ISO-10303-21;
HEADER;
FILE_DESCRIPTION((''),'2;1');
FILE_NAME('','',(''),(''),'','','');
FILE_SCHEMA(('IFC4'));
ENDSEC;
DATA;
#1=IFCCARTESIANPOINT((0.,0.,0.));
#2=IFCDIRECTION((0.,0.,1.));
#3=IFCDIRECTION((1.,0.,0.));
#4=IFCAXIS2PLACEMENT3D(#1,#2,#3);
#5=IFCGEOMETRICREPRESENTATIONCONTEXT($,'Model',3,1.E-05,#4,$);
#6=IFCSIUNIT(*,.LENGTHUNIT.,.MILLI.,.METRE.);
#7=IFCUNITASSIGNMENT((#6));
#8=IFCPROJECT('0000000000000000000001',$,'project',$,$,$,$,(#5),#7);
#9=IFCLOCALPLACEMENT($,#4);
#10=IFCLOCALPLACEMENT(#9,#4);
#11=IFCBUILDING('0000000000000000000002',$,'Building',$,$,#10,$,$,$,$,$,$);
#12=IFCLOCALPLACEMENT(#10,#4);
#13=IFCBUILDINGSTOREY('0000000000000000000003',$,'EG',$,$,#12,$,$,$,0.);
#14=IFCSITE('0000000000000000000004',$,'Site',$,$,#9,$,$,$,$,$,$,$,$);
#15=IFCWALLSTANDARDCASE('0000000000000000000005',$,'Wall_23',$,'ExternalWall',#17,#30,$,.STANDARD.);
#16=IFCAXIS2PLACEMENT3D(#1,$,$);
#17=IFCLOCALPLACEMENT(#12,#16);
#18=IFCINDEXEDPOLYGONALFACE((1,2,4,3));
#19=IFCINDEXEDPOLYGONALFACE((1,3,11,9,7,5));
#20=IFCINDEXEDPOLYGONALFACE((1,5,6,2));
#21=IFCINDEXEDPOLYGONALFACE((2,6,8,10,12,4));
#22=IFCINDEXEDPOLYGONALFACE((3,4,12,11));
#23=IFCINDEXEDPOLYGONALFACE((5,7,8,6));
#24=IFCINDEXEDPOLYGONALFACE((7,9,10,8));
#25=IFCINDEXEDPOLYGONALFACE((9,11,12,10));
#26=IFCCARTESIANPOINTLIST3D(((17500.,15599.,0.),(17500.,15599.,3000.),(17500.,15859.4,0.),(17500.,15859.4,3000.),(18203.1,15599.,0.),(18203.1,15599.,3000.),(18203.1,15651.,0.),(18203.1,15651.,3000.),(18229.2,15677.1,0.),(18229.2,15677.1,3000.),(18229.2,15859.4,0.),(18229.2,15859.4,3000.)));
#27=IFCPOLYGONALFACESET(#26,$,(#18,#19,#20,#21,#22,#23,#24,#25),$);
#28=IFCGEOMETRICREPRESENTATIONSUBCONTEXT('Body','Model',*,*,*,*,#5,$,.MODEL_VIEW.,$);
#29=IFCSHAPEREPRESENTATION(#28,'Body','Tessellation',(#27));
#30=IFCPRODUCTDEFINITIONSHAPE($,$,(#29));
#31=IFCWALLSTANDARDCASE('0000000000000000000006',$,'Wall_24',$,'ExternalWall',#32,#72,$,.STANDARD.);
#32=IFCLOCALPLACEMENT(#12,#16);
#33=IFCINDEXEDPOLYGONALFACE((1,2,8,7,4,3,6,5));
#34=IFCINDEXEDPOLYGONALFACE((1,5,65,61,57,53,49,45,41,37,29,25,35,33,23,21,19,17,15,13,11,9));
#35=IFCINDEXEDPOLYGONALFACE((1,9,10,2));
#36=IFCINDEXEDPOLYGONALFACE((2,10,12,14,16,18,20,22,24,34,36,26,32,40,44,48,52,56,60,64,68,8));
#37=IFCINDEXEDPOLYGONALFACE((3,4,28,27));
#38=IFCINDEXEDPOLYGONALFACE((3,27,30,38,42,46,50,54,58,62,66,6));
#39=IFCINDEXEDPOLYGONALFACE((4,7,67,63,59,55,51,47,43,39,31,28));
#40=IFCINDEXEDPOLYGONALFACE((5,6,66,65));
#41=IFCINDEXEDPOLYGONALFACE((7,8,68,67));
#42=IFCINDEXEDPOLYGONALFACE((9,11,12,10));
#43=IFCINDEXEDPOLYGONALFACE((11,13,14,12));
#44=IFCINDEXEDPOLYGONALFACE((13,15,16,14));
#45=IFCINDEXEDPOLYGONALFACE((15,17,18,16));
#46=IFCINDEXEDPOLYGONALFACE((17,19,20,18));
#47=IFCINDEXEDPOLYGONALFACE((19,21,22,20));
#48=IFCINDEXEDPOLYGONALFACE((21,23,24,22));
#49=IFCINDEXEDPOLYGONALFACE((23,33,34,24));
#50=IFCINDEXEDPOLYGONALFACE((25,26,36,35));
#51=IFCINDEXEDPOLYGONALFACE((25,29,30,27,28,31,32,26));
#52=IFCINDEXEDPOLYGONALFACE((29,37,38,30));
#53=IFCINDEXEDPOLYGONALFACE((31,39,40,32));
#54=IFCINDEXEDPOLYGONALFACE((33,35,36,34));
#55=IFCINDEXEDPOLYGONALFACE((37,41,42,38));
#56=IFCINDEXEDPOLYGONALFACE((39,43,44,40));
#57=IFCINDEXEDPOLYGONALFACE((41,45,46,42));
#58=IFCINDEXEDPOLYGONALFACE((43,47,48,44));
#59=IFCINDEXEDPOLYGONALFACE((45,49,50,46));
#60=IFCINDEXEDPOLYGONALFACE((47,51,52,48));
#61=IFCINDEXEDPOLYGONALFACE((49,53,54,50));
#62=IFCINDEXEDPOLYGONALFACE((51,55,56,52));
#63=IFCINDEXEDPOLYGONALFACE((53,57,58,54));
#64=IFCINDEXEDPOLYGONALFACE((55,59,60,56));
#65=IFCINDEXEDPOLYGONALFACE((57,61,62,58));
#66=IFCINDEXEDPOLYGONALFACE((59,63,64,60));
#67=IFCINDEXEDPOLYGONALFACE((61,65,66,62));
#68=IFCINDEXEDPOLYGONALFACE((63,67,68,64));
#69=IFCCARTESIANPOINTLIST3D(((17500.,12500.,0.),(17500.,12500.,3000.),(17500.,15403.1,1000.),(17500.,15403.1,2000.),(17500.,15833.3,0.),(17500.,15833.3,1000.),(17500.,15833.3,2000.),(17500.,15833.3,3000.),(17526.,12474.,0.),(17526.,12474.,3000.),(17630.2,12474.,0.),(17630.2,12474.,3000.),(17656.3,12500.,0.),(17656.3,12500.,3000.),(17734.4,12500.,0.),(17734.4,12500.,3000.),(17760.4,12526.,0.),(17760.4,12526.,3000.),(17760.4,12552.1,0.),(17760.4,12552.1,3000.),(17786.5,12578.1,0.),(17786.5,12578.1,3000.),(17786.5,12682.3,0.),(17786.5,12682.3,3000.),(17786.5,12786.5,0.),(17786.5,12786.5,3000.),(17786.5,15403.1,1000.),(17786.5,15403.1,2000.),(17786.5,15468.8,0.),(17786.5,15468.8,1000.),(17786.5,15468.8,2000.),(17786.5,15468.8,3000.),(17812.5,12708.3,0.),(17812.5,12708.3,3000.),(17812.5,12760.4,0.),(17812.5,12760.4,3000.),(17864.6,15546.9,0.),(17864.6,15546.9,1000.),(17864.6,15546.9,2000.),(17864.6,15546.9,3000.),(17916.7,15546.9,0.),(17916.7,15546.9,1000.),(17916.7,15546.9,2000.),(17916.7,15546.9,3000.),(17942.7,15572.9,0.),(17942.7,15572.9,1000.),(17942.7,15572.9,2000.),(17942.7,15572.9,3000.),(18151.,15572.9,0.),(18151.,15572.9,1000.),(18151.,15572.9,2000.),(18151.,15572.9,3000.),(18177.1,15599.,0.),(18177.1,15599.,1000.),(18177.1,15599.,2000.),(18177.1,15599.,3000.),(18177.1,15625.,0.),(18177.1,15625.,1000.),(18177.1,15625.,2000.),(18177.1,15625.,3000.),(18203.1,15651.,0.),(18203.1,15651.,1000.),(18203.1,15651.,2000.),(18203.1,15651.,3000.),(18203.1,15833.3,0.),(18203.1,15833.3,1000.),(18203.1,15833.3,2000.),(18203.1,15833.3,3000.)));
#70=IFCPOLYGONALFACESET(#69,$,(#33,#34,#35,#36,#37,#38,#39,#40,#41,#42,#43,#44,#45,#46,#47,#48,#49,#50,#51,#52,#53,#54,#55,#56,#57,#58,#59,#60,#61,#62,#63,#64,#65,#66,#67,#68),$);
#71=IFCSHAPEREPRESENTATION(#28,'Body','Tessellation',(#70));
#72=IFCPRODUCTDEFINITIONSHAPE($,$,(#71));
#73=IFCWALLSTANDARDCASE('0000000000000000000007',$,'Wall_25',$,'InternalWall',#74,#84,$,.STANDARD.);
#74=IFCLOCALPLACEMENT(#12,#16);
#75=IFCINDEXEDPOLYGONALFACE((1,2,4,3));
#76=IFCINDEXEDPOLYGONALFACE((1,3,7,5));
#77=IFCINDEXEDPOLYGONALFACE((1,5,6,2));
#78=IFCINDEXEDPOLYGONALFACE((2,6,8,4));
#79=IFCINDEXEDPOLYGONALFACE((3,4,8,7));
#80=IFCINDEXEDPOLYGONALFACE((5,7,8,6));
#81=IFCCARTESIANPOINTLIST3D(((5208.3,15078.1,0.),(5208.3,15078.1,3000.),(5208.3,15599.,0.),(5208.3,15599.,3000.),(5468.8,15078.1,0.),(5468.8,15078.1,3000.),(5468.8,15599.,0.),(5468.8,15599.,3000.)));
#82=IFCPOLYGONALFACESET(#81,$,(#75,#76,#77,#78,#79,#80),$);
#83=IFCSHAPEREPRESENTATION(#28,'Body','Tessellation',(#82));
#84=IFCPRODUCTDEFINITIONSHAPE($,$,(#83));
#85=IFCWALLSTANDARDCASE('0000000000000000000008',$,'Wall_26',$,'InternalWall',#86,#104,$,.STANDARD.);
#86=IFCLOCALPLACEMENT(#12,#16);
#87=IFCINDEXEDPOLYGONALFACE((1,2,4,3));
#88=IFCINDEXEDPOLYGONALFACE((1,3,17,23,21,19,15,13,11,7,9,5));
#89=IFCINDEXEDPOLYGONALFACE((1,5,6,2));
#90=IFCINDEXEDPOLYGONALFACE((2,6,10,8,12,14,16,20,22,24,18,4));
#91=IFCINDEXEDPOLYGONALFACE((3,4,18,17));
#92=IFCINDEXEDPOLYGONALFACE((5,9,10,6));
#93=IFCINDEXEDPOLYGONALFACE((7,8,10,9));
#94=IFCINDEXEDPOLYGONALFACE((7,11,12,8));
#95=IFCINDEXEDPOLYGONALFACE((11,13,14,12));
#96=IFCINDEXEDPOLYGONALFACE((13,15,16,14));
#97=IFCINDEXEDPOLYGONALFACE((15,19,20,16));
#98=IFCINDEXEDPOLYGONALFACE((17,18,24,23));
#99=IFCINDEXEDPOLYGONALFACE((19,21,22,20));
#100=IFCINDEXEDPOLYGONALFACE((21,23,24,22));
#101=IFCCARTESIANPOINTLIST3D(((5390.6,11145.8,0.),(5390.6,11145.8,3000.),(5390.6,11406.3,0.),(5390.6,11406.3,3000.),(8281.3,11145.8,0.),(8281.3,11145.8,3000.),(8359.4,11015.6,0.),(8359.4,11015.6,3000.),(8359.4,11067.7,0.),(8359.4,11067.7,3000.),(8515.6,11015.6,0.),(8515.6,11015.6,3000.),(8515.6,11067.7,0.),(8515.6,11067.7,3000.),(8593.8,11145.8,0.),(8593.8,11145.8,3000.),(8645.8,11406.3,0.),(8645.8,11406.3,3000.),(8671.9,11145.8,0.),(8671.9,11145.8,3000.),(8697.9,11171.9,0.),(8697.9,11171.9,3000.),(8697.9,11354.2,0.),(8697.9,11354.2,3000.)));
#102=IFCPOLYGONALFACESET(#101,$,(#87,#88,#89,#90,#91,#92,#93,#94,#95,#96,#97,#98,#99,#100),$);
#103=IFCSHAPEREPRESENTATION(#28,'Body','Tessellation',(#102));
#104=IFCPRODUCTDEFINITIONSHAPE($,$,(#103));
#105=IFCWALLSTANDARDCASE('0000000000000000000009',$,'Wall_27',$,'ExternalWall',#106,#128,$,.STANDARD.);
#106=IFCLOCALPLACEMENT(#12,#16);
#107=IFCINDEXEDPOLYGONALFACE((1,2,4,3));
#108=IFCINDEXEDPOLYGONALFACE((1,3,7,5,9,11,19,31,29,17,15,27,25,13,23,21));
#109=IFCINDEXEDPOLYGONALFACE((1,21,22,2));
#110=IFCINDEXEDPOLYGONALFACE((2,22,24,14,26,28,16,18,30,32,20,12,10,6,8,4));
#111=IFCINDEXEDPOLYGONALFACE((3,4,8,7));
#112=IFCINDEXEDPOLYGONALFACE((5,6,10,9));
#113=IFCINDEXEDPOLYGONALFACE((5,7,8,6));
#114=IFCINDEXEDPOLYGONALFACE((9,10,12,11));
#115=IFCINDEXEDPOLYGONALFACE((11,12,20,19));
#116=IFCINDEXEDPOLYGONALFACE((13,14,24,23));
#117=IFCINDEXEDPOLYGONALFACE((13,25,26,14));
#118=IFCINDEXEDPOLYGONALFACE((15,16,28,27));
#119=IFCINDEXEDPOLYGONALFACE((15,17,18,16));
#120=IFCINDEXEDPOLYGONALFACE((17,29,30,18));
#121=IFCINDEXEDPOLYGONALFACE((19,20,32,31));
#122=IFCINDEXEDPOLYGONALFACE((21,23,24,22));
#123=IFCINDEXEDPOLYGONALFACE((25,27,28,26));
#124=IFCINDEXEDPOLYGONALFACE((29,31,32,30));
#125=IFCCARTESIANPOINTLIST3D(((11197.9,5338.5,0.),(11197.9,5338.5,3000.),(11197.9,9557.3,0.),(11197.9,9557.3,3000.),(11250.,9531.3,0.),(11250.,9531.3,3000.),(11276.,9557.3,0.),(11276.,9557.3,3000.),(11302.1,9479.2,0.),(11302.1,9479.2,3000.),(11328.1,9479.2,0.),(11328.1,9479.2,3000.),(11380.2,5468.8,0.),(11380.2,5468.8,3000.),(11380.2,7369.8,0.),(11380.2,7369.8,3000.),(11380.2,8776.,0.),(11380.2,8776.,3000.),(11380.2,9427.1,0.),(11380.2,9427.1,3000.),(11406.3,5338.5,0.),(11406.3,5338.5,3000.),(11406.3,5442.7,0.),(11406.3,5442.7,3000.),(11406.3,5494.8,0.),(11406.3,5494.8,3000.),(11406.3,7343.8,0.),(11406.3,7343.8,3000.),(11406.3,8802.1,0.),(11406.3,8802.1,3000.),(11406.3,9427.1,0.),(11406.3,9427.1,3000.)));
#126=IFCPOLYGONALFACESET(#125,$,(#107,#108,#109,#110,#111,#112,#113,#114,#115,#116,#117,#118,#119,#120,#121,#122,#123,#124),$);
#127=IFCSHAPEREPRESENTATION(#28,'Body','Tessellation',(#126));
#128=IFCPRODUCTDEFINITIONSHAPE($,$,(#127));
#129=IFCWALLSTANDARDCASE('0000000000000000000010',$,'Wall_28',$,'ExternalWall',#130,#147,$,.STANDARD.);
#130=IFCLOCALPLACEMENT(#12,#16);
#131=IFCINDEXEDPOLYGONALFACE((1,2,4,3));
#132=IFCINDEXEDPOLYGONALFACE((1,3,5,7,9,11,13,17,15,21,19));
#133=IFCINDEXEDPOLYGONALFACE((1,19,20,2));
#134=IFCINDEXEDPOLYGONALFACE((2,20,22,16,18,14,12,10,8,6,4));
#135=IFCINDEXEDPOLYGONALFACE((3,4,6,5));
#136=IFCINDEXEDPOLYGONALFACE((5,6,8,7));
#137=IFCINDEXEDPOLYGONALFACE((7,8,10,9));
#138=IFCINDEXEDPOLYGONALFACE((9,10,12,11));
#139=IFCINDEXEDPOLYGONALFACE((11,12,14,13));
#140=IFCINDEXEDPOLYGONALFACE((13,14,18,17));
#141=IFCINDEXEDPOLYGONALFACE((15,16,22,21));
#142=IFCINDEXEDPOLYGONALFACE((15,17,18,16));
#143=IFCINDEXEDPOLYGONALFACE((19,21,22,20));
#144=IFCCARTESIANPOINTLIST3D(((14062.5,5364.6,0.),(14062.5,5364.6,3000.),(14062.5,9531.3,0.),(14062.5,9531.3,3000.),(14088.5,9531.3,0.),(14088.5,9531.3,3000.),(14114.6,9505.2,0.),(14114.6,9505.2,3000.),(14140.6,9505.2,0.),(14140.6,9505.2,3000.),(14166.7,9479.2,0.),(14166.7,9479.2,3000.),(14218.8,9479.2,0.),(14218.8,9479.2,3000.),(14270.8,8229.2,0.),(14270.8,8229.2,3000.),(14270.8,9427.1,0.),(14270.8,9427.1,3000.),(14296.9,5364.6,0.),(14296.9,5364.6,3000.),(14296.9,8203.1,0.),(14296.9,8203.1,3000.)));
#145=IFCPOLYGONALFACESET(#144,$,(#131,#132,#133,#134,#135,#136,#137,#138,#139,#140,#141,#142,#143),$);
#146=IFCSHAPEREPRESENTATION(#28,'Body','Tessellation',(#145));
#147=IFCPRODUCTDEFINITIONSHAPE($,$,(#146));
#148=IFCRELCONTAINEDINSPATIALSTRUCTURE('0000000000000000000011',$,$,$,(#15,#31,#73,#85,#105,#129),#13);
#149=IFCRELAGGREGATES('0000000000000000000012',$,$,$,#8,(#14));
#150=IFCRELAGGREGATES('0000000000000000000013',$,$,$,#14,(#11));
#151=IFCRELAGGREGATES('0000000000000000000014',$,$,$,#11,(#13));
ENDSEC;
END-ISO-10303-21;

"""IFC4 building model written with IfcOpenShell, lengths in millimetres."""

from ifc_helpers import new_model, si_unit, frame, origin_with_axes, place, context, subcontext, project, spatial, polyline, rectangle, outline, extrude, element, save


model = new_model("IFC4")

# Units and contexts
model_context = context("Model", 3, precision=1e-05, world=origin_with_axes())
body_context = subcontext(model_context, "Body", "Model", "MODEL_VIEW")
ifc_project = project(units=[si_unit("LENGTHUNIT", "METRE", prefix="MILLI")], contexts=[model_context])

# Site, building, storey
site_placement = place(None, origin_with_axes())
site = spatial("IfcSite", under=ifc_project, at=site_placement, Name="Site")
building_placement = place(site_placement, origin_with_axes())
building = spatial("IfcBuilding", under=site, at=building_placement, Name="Building")
storey_placement = place(building_placement, origin_with_axes())
storey = spatial("IfcBuildingStorey", under=building, at=storey_placement, Name="EG", Elevation=0.0)

# Wall
wall_1_placement = place(storey_placement, origin_with_axes())
element("IfcWallStandardCase", 1, at=wall_1_placement, inside=storey, Name="Wall_23", ObjectType="ExternalWall", PredefinedType="STANDARD", context=body_context, shape_type="SweptSolid", body=[
    extrude(outline(polyline([(17500.0, 15599.0, 0.0), (17500.0, 15859.4, 0.0), (18229.2, 15859.4, 0.0), (18229.2, 15677.1, 0.0), (18203.1, 15651.0, 0.0), (18203.1, 15599.0, 0.0), (17500.0, 15599.0, 0.0)])), origin_with_axes(), (0.0, 0.0, 1.0), 3000.0),
])

# Wall, opening
wall_2_placement = place(storey_placement, origin_with_axes())
wall_2 = element("IfcWallStandardCase", 2, at=wall_2_placement, inside=storey, Name="Wall_24", ObjectType="ExternalWall", PredefinedType="STANDARD", context=body_context, shape_type="SweptSolid", body=[
    extrude(outline(polyline([(17526.0, 12474.0, 0.0), (17500.0, 12500.0, 0.0), (17500.0, 15833.3, 0.0), (18203.1, 15833.3, 0.0), (18203.1, 15651.0, 0.0), (18177.1, 15625.0, 0.0), (18177.1, 15599.0, 0.0), (18151.0, 15572.9, 0.0), (17942.7, 15572.9, 0.0), (17916.7, 15546.9, 0.0), (17864.6, 15546.9, 0.0), (17786.5, 15468.8, 0.0), (17786.5, 12786.5, 0.0), (17812.5, 12760.4, 0.0), (17812.5, 12708.3, 0.0), (17786.5, 12682.3, 0.0), (17786.5, 12578.1, 0.0), (17760.4, 12552.1, 0.0), (17760.4, 12526.0, 0.0), (17734.4, 12500.0, 0.0), (17656.3, 12500.0, 0.0), (17630.2, 12474.0, 0.0), (17526.0, 12474.0, 0.0)])), origin_with_axes(), (0.0, 0.0, 1.0), 3000.0),
])
opening_1_placement = place(wall_2_placement, origin_with_axes())
element("IfcOpeningElement", 3, at=opening_1_placement, inside=storey, cuts=wall_2, context=body_context, shape_type="SweptSolid", body=[
    extrude(rectangle(XDim=600.0, YDim=703.1), frame((17851.6, 15703.1, 1000.0), z_axis=(0.0, 0.0, 1.0), x_axis=(0.0, 1.0, 0.0)), (0.0, 0.0, 1.0), 1000.0),
])

# Walls
wall_3_placement = place(storey_placement, origin_with_axes())
element("IfcWallStandardCase", 4, at=wall_3_placement, inside=storey, Name="Wall_25", ObjectType="InternalWall", PredefinedType="STANDARD", context=body_context, shape_type="SweptSolid", body=[
    extrude(outline(polyline([(5208.3, 15078.1, 0.0), (5208.3, 15599.0, 0.0), (5468.8, 15599.0, 0.0), (5468.8, 15078.1, 0.0), (5208.3, 15078.1, 0.0)])), origin_with_axes(), (0.0, 0.0, 1.0), 3000.0),
])
wall_4_placement = place(storey_placement, origin_with_axes())
element("IfcWallStandardCase", 5, at=wall_4_placement, inside=storey, Name="Wall_26", ObjectType="InternalWall", PredefinedType="STANDARD", context=body_context, shape_type="SweptSolid", body=[
    extrude(outline(polyline([(8359.4, 11015.6, 0.0), (8359.4, 11067.7, 0.0), (8281.3, 11145.8, 0.0), (5390.6, 11145.8, 0.0), (5390.6, 11406.3, 0.0), (8645.8, 11406.3, 0.0), (8697.9, 11354.2, 0.0), (8697.9, 11171.9, 0.0), (8671.9, 11145.8, 0.0), (8593.8, 11145.8, 0.0), (8515.6, 11067.7, 0.0), (8515.6, 11015.6, 0.0), (8359.4, 11015.6, 0.0)])), origin_with_axes(), (0.0, 0.0, 1.0), 3000.0),
])
wall_5_placement = place(storey_placement, origin_with_axes())
element("IfcWallStandardCase", 6, at=wall_5_placement, inside=storey, Name="Wall_27", ObjectType="ExternalWall", PredefinedType="STANDARD", context=body_context, shape_type="SweptSolid", body=[
    extrude(outline(polyline([(11197.9, 5338.5, 0.0), (11197.9, 9557.3, 0.0), (11276.0, 9557.3, 0.0), (11250.0, 9531.3, 0.0), (11302.1, 9479.2, 0.0), (11328.1, 9479.2, 0.0), (11380.2, 9427.1, 0.0), (11406.3, 9427.1, 0.0), (11406.3, 8802.1, 0.0), (11380.2, 8776.0, 0.0), (11380.2, 7369.8, 0.0), (11406.3, 7343.8, 0.0), (11406.3, 5494.8, 0.0), (11380.2, 5468.8, 0.0), (11406.3, 5442.7, 0.0), (11406.3, 5338.5, 0.0), (11197.9, 5338.5, 0.0)])), origin_with_axes(), (0.0, 0.0, 1.0), 3000.0),
])
wall_6_placement = place(storey_placement, origin_with_axes())
element("IfcWallStandardCase", 7, at=wall_6_placement, inside=storey, Name="Wall_28", ObjectType="ExternalWall", PredefinedType="STANDARD", context=body_context, shape_type="SweptSolid", body=[
    extrude(outline(polyline([(14062.5, 5364.6, 0.0), (14062.5, 9531.3, 0.0), (14088.5, 9531.3, 0.0), (14114.6, 9505.2, 0.0), (14140.6, 9505.2, 0.0), (14166.7, 9479.2, 0.0), (14218.8, 9479.2, 0.0), (14270.8, 9427.1, 0.0), (14270.8, 8229.2, 0.0), (14296.9, 8203.1, 0.0), (14296.9, 5364.6, 0.0), (14062.5, 5364.6, 0.0)])), origin_with_axes(), (0.0, 0.0, 1.0), 3000.0),
])

save(model, "model.ifc")
